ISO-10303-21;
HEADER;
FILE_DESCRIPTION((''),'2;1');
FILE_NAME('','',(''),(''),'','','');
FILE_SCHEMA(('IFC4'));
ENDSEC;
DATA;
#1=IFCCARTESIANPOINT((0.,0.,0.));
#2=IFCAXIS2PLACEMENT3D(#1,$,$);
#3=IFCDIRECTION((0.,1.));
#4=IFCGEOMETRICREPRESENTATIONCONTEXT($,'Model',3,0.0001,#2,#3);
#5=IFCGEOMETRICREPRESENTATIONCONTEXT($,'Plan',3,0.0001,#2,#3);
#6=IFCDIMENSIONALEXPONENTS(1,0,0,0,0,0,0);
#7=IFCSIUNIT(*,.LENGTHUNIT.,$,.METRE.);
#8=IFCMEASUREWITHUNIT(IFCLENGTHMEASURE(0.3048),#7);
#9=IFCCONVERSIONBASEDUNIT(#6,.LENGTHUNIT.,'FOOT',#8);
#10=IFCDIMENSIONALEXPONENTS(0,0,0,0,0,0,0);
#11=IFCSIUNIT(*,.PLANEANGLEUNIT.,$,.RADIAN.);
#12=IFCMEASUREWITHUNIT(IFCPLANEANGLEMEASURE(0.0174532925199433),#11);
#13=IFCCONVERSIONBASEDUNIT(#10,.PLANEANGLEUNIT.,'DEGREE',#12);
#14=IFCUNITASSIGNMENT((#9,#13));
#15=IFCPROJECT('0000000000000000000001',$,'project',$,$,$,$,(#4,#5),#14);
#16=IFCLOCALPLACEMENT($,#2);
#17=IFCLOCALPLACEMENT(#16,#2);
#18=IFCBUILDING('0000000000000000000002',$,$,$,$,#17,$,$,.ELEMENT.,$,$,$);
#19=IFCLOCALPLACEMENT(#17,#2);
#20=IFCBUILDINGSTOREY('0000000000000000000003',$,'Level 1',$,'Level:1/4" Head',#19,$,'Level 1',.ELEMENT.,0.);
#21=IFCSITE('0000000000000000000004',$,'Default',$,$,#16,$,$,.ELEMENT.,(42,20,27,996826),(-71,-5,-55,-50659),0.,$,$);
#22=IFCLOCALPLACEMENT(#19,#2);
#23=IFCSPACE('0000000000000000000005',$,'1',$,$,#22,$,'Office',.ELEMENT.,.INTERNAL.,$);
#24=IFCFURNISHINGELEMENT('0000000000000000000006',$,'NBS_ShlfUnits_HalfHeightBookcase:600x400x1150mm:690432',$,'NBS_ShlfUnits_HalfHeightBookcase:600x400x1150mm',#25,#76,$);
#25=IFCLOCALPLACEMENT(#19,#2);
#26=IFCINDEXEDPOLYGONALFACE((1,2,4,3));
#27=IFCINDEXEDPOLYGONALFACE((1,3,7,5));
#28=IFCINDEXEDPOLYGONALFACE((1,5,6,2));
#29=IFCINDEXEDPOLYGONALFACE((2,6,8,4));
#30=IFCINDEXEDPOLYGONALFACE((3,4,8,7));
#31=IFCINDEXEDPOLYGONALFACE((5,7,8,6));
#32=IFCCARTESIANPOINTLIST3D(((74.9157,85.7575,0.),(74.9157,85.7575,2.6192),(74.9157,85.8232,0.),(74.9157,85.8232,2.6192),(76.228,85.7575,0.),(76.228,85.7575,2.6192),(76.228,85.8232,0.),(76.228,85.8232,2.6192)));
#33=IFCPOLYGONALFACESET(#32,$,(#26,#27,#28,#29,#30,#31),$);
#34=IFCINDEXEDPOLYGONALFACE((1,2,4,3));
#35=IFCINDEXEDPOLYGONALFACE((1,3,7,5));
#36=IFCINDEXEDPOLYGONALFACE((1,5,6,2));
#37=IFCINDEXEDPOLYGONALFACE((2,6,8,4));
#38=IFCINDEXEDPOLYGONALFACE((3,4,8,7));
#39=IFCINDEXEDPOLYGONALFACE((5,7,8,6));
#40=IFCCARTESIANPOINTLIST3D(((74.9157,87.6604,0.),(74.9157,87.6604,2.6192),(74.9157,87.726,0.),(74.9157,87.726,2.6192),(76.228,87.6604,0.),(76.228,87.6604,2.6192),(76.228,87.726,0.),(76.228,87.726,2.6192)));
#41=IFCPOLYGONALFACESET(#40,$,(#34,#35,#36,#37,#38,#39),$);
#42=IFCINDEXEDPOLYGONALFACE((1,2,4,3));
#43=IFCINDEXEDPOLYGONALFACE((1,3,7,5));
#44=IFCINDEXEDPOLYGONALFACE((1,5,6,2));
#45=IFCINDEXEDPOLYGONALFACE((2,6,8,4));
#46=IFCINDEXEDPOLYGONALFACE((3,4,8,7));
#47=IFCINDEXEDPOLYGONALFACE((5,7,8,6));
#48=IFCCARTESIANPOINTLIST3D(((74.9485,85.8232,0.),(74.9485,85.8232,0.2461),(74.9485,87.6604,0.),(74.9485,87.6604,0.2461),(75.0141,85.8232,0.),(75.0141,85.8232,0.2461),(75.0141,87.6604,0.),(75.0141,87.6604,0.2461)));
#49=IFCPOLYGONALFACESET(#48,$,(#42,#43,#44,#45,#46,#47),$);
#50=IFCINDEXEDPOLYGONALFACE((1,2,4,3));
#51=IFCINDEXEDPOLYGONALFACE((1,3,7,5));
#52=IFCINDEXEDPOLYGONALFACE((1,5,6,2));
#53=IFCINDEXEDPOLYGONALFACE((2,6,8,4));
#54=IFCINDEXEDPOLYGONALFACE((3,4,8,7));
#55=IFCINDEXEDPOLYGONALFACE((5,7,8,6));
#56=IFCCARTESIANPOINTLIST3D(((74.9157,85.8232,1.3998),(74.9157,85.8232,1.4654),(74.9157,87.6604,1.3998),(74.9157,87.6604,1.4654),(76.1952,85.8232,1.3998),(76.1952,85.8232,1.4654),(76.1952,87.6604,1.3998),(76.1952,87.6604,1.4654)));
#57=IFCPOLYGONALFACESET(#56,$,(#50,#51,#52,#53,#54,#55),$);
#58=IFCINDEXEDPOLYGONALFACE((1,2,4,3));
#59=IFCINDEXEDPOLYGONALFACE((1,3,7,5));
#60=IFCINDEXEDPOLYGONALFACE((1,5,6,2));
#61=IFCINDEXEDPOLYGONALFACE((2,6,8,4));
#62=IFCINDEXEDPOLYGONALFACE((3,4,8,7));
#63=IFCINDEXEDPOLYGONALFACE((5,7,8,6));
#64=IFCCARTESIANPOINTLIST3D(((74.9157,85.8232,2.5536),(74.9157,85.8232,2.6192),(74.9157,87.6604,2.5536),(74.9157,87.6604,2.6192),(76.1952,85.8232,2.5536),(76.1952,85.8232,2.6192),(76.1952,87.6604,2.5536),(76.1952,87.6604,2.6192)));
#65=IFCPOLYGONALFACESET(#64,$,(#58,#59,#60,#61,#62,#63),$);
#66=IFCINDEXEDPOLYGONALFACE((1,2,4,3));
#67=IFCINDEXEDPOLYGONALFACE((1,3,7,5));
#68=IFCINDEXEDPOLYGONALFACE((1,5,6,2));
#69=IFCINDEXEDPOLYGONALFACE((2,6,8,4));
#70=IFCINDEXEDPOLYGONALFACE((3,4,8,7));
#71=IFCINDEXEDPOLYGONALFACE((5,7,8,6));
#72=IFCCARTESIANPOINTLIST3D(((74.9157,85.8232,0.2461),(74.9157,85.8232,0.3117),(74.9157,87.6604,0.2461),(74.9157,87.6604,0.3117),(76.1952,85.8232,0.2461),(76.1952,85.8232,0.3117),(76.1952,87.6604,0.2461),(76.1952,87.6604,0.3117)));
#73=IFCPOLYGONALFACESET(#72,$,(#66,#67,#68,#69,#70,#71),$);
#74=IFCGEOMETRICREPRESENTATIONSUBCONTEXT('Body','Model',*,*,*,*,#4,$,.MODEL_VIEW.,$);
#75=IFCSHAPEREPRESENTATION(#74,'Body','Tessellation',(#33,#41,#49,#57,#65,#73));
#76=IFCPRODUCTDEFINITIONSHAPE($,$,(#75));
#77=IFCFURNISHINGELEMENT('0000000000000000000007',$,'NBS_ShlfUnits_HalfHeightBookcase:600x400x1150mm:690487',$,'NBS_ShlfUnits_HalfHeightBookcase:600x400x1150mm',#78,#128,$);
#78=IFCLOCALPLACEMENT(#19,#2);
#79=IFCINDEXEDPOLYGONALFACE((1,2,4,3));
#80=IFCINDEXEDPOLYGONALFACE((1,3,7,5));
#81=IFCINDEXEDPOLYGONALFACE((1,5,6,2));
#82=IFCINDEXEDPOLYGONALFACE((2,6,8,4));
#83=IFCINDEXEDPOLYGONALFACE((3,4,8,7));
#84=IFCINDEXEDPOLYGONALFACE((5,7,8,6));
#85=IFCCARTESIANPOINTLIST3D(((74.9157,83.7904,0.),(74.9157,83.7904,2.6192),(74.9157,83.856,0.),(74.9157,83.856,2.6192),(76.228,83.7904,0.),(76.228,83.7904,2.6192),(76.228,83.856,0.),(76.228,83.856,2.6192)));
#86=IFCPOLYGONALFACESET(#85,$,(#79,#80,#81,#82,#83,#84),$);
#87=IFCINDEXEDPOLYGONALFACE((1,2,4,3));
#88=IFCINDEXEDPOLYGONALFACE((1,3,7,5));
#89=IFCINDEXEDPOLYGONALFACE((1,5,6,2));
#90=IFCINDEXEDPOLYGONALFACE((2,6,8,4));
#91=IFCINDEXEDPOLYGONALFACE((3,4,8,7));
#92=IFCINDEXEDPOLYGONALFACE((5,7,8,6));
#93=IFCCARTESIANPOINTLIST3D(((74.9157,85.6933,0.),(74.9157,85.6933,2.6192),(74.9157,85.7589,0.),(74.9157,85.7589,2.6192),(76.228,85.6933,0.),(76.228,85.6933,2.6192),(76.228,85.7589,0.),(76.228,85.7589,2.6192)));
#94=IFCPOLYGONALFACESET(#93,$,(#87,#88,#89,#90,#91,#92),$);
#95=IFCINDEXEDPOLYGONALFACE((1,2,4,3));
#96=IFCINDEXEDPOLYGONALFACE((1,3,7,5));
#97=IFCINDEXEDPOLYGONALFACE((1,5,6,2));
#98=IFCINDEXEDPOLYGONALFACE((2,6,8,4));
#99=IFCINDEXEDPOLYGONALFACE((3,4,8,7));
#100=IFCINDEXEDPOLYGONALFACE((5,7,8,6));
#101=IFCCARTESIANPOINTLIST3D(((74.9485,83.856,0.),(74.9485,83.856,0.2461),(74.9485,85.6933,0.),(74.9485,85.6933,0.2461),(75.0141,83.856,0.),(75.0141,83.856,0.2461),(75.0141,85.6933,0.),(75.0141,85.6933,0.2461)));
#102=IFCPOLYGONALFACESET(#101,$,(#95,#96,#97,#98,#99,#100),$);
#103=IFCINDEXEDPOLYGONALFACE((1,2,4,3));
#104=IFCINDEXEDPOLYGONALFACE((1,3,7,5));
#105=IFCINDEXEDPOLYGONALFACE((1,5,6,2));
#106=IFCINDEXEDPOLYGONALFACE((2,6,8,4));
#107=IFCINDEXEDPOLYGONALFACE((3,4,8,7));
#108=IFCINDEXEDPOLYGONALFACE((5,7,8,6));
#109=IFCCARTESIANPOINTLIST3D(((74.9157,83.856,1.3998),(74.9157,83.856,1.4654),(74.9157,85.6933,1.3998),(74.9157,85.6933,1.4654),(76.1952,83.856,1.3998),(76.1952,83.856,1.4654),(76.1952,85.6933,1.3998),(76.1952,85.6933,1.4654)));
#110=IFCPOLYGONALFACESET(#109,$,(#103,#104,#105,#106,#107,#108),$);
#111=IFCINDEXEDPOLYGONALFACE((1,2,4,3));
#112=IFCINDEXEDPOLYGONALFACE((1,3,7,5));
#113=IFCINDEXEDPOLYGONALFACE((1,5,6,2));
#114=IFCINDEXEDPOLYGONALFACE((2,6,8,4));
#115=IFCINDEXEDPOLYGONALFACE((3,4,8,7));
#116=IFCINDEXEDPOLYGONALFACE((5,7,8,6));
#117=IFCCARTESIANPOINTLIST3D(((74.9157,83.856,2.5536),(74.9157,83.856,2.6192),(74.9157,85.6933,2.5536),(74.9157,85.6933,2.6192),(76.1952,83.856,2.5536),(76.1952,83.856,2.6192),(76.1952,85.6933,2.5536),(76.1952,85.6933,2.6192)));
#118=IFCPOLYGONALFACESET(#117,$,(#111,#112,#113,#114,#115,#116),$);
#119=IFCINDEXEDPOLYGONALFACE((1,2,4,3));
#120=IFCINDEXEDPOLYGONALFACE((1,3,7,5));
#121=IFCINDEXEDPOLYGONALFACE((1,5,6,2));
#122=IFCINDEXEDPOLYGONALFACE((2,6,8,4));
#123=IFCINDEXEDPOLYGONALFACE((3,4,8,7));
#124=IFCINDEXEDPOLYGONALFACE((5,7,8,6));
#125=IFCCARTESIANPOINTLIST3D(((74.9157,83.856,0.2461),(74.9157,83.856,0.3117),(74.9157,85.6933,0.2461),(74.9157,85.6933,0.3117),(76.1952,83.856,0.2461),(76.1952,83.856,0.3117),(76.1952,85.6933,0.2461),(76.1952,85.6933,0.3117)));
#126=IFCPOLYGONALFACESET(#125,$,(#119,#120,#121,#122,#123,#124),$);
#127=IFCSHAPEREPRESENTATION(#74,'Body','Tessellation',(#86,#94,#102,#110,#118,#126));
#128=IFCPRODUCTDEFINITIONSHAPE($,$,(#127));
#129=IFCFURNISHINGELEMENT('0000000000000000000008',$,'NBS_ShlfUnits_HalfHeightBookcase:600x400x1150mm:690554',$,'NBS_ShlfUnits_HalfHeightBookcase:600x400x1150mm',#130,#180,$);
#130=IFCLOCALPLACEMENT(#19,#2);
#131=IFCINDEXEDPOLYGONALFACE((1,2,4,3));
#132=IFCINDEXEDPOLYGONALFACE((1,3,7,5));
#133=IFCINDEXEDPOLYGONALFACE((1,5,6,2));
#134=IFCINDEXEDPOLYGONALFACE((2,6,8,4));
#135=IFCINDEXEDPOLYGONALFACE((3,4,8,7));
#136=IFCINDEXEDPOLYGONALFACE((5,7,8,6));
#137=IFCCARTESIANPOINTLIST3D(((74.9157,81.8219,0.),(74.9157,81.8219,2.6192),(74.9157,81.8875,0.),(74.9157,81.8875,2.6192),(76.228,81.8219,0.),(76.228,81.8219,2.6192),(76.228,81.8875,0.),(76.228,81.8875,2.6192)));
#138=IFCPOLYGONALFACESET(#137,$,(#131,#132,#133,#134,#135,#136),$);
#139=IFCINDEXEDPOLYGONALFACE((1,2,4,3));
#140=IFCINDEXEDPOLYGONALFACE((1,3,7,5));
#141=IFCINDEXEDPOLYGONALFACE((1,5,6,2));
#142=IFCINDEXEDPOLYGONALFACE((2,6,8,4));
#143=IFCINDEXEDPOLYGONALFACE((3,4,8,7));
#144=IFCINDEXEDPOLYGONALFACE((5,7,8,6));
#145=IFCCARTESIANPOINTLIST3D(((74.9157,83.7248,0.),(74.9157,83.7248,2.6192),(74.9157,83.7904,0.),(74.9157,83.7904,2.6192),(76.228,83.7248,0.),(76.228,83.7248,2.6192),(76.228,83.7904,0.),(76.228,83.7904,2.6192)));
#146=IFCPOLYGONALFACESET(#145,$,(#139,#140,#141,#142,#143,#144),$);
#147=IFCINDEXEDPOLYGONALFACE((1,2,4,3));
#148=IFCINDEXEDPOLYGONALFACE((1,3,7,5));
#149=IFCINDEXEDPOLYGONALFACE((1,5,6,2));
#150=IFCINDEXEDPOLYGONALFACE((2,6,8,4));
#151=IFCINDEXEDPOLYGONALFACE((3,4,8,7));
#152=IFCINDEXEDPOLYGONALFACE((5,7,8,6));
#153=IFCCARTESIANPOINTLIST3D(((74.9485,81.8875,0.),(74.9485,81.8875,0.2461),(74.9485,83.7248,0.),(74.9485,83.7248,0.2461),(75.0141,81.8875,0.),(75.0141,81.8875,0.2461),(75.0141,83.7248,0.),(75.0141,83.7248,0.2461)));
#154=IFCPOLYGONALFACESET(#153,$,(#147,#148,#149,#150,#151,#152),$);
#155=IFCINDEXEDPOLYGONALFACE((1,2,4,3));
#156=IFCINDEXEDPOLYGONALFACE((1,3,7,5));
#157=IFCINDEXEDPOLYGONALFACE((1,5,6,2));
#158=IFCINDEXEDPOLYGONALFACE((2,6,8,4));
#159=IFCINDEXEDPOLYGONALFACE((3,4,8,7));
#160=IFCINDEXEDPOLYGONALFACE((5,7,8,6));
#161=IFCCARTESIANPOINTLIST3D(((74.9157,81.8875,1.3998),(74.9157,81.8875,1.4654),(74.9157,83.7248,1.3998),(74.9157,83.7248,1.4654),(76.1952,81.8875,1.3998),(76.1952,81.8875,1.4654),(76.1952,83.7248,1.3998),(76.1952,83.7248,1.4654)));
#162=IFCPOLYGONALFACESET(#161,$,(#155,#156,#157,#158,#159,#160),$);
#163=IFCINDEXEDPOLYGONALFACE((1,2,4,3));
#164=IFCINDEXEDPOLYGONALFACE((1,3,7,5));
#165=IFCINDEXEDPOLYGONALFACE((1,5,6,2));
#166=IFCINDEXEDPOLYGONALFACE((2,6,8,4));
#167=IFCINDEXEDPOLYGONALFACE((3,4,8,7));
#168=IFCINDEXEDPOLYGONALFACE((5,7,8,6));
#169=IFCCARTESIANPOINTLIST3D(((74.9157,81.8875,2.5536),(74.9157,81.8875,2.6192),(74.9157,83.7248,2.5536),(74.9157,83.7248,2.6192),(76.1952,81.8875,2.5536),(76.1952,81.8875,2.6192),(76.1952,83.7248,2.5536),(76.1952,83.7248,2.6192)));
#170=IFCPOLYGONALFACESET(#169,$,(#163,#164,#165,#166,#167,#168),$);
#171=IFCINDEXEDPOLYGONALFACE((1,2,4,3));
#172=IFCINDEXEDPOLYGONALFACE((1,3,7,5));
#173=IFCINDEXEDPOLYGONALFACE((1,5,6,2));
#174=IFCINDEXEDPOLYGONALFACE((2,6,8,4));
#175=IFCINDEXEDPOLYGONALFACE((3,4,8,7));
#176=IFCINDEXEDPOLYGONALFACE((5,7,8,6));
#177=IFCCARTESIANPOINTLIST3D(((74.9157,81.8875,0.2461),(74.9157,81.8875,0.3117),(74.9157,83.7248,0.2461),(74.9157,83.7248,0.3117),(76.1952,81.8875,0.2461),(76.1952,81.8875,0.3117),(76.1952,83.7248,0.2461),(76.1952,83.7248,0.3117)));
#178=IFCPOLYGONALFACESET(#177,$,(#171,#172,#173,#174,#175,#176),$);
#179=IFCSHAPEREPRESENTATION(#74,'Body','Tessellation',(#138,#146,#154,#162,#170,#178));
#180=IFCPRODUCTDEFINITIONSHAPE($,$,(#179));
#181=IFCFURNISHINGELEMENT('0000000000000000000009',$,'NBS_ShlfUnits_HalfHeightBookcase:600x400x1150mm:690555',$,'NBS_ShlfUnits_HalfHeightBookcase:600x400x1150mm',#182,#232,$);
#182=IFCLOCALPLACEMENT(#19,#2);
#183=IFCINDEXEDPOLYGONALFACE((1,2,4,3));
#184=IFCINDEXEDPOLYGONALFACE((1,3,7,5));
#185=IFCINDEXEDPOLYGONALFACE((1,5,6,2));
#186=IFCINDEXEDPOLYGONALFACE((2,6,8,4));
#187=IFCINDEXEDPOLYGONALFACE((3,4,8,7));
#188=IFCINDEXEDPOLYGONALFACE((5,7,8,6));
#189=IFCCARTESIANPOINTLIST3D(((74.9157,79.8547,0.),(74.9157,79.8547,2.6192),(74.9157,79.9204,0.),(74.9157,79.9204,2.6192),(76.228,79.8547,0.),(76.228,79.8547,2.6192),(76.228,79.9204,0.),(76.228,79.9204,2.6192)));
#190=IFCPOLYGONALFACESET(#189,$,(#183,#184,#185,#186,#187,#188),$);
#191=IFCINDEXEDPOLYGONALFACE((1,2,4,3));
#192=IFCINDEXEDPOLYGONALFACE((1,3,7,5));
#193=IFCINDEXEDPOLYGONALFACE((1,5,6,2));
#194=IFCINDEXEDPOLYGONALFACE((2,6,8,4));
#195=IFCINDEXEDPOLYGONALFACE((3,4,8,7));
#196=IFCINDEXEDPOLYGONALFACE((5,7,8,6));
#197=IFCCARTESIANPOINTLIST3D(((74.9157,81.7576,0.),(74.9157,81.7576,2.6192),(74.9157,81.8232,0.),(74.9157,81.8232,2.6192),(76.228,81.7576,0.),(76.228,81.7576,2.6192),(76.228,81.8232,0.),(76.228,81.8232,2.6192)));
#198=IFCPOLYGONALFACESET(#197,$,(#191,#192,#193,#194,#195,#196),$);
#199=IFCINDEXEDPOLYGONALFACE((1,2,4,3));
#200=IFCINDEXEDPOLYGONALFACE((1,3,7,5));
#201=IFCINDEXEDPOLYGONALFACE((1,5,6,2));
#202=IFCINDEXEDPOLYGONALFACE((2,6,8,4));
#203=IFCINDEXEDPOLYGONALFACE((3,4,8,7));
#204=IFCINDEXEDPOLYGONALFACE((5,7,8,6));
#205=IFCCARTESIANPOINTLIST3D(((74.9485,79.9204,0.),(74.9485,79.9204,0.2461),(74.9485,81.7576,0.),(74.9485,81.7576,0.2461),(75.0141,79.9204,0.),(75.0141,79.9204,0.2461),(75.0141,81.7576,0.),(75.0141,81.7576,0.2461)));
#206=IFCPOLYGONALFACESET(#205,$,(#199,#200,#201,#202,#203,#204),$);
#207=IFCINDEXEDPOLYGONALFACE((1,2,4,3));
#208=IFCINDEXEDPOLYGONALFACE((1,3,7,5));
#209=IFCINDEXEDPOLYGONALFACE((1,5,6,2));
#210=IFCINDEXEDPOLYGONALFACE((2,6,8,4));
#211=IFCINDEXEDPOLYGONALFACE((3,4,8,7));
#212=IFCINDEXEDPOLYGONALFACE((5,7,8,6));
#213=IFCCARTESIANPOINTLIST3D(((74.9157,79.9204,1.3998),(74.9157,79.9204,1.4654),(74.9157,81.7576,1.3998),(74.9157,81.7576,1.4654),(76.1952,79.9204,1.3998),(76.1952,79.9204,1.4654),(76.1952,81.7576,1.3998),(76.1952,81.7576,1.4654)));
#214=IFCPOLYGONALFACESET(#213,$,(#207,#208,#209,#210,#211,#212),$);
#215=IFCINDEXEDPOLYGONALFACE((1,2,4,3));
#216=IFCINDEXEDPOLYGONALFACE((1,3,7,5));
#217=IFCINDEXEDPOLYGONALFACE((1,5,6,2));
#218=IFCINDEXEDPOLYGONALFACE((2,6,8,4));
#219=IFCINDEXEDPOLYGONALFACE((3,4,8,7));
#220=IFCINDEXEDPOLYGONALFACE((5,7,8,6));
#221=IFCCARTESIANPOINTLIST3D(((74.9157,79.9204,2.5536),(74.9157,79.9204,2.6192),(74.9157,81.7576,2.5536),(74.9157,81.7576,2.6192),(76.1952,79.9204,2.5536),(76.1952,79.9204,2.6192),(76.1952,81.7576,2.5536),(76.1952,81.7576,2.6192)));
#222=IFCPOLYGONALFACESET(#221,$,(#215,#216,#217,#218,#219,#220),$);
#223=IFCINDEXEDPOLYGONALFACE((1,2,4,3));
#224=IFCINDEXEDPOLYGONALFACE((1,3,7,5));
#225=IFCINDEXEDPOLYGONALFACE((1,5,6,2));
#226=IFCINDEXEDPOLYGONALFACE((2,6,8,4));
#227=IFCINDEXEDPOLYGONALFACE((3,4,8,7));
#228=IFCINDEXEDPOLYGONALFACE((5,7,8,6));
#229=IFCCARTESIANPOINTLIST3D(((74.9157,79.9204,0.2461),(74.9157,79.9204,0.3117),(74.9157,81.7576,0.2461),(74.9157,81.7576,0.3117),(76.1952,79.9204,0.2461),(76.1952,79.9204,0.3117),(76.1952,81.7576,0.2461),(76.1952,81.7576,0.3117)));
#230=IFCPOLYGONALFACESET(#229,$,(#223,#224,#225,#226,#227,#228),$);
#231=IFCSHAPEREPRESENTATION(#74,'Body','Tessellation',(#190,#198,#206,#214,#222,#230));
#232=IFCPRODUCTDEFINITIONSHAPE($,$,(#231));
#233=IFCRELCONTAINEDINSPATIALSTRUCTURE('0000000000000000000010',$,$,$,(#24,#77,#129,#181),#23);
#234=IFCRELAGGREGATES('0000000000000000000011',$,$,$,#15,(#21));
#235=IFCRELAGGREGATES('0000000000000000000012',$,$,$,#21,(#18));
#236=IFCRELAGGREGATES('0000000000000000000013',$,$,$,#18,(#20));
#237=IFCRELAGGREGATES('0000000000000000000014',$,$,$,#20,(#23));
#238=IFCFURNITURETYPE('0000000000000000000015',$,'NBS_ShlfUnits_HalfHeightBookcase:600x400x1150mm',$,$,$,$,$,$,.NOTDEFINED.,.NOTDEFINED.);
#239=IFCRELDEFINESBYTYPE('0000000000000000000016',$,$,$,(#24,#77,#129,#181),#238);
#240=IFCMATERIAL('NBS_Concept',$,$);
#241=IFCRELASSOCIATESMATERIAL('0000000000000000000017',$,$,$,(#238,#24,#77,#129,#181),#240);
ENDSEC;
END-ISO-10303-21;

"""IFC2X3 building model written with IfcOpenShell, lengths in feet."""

from ifc_helpers import new_model, entity, si_unit, converted_unit, direction, frame, frame_2d, origin, origin_2d_with_axis, place, context, subcontext, project, spatial, rectangle, extrude, source, transform, mapped, material, type_object, type_shapes, element, save


model = new_model("IFC2X3")

# Units and contexts
model_context = context("Model", 3, precision=0.0001, world=origin(), true_north=direction((0.0, 1.0)))
plan_context = context("Plan", 3, precision=0.0001, world=origin(), true_north=direction((0.0, 1.0)))
body_context = subcontext(model_context, "Body", "Model", "MODEL_VIEW")
ifc_project = project(units=[converted_unit("LENGTHUNIT", "FOOT", entity("IfcLengthMeasure", 0.3048), si_unit("LENGTHUNIT", "METRE"), dimensions=[1, 0, 0, 0, 0, 0, 0]), converted_unit("PLANEANGLEUNIT", "DEGREE", entity("IfcPlaneAngleMeasure", 0.0174532925199433), si_unit("PLANEANGLEUNIT", "RADIAN"), dimensions=[0, 0, 0, 0, 0, 0, 0])], contexts=[model_context, plan_context])

# Site, building, storey
site_placement = place(None, origin())
site = spatial("IfcSite", under=ifc_project, at=site_placement, Name="Default", CompositionType="ELEMENT", RefLatitude=(42, 20, 27, 996826), RefLongitude=(-71, -5, -55, -50659), RefElevation=0.0)
building_placement = place(site_placement, origin())
building = spatial("IfcBuilding", under=site, at=building_placement, CompositionType="ELEMENT")
storey_placement = place(building_placement, origin())
storey = spatial("IfcBuildingStorey", under=building, at=storey_placement, Name="Level 1", ObjectType="Level:1/4\" Head", LongName="Level 1", CompositionType="ELEMENT", Elevation=0.0)

# Shared definitions
space_1_placement = place(storey_placement, origin())
space_1 = spatial("IfcSpace", under=storey, at=space_1_placement, Name="1", LongName="Office", CompositionType="ELEMENT", InteriorOrExteriorSpace="INTERNAL")

# Furnishing elements
ifc_material_1 = material(Name="NBS_Concept")
furniture_type_1 = type_object("IfcFurnitureType", Name="NBS_ShlfUnits_HalfHeightBookcase:600x400x1150mm", AssemblyPlace="NOTDEFINED", material=ifc_material_1)
shared_shape_1 = source(origin(), body_context, "Body", "SweptSolid", [
    extrude(rectangle(XDim=0.0656, YDim=1.3123, at=origin_2d_with_axis()), frame((0.9514, -0.6562, 0.0), z_axis=(0.0, 0.0, 1.0), x_axis=(-1.0, 0.0, 0.0)), (0.0, 0.0, 1.0), 2.6192),
    extrude(rectangle(XDim=0.0656, YDim=1.3123, at=origin_2d_with_axis()), frame((-0.9514, -0.6562, 0.0), z_axis=(0.0, 0.0, 1.0), x_axis=(-1.0, 0.0, 0.0)), (0.0, 0.0, 1.0), 2.6192),
    extrude(rectangle(XDim=1.8373, YDim=0.0656, at=origin_2d_with_axis()), frame((0.0, -1.2467, 0.0), z_axis=(0.0, 0.0, 1.0), x_axis=(-1.0, 0.0, 0.0)), (0.0, 0.0, 1.0), 0.2461),
    extrude(rectangle(XDim=1.2795, YDim=1.8373, at=frame_2d((0.0, 0.0), x_axis=(1.0, 0.0))), frame((0.0, -0.6726, 1.3998), z_axis=(0.0, 0.0, 1.0), x_axis=(0.0, 1.0, 0.0)), (0.0, 0.0, 1.0), 0.0656),
    extrude(rectangle(XDim=1.2795, YDim=1.8373, at=frame_2d((0.0, 0.0), x_axis=(1.0, 0.0))), frame((0.0, -0.6726, 2.5536), z_axis=(0.0, 0.0, 1.0), x_axis=(0.0, 1.0, 0.0)), (0.0, 0.0, 1.0), 0.0656),
    extrude(rectangle(XDim=1.2795, YDim=1.8373, at=frame_2d((0.0, 0.0), x_axis=(1.0, 0.0))), frame((0.0, -0.6726, 0.2461), z_axis=(0.0, 0.0, 1.0), x_axis=(0.0, 1.0, 0.0)), (0.0, 0.0, 1.0), 0.0656),
])
type_shapes(furniture_type_1, [shared_shape_1])
for number, where, z_axis, x_axis, name in (
    (1, (76.228, 86.7418, 0.0), (0.0, 0.0, 1.0), (0.0, -1.0, 0.0), "NBS_ShlfUnits_HalfHeightBookcase:600x400x1150mm:690432"),
    (2, (76.228, 84.7746, 0.0), (0.0, 0.0, 1.0), (0.0, -1.0, 0.0), "NBS_ShlfUnits_HalfHeightBookcase:600x400x1150mm:690487"),
    (3, (76.228, 82.8061, 0.0), (0.0, 0.0, 1.0), (0.0, -1.0, 0.0), "NBS_ShlfUnits_HalfHeightBookcase:600x400x1150mm:690554"),
    (4, (76.228, 80.839, 0.0), (0.0, 0.0, 1.0), (0.0, -1.0, 0.0), "NBS_ShlfUnits_HalfHeightBookcase:600x400x1150mm:690555"),
):
    element("IfcFurnishingElement", number, at=place(space_1_placement, frame(where, z_axis=z_axis, x_axis=x_axis)), inside=space_1, type_object=furniture_type_1, material=ifc_material_1, Name=name, ObjectType="NBS_ShlfUnits_HalfHeightBookcase:600x400x1150mm", context=body_context, shape_type="MappedRepresentation", body=[
        mapped(shared_shape_1, transform((0.0, 0.0, 0.0), scale=1.0)),
    ])

save(model, "model.ifc")
